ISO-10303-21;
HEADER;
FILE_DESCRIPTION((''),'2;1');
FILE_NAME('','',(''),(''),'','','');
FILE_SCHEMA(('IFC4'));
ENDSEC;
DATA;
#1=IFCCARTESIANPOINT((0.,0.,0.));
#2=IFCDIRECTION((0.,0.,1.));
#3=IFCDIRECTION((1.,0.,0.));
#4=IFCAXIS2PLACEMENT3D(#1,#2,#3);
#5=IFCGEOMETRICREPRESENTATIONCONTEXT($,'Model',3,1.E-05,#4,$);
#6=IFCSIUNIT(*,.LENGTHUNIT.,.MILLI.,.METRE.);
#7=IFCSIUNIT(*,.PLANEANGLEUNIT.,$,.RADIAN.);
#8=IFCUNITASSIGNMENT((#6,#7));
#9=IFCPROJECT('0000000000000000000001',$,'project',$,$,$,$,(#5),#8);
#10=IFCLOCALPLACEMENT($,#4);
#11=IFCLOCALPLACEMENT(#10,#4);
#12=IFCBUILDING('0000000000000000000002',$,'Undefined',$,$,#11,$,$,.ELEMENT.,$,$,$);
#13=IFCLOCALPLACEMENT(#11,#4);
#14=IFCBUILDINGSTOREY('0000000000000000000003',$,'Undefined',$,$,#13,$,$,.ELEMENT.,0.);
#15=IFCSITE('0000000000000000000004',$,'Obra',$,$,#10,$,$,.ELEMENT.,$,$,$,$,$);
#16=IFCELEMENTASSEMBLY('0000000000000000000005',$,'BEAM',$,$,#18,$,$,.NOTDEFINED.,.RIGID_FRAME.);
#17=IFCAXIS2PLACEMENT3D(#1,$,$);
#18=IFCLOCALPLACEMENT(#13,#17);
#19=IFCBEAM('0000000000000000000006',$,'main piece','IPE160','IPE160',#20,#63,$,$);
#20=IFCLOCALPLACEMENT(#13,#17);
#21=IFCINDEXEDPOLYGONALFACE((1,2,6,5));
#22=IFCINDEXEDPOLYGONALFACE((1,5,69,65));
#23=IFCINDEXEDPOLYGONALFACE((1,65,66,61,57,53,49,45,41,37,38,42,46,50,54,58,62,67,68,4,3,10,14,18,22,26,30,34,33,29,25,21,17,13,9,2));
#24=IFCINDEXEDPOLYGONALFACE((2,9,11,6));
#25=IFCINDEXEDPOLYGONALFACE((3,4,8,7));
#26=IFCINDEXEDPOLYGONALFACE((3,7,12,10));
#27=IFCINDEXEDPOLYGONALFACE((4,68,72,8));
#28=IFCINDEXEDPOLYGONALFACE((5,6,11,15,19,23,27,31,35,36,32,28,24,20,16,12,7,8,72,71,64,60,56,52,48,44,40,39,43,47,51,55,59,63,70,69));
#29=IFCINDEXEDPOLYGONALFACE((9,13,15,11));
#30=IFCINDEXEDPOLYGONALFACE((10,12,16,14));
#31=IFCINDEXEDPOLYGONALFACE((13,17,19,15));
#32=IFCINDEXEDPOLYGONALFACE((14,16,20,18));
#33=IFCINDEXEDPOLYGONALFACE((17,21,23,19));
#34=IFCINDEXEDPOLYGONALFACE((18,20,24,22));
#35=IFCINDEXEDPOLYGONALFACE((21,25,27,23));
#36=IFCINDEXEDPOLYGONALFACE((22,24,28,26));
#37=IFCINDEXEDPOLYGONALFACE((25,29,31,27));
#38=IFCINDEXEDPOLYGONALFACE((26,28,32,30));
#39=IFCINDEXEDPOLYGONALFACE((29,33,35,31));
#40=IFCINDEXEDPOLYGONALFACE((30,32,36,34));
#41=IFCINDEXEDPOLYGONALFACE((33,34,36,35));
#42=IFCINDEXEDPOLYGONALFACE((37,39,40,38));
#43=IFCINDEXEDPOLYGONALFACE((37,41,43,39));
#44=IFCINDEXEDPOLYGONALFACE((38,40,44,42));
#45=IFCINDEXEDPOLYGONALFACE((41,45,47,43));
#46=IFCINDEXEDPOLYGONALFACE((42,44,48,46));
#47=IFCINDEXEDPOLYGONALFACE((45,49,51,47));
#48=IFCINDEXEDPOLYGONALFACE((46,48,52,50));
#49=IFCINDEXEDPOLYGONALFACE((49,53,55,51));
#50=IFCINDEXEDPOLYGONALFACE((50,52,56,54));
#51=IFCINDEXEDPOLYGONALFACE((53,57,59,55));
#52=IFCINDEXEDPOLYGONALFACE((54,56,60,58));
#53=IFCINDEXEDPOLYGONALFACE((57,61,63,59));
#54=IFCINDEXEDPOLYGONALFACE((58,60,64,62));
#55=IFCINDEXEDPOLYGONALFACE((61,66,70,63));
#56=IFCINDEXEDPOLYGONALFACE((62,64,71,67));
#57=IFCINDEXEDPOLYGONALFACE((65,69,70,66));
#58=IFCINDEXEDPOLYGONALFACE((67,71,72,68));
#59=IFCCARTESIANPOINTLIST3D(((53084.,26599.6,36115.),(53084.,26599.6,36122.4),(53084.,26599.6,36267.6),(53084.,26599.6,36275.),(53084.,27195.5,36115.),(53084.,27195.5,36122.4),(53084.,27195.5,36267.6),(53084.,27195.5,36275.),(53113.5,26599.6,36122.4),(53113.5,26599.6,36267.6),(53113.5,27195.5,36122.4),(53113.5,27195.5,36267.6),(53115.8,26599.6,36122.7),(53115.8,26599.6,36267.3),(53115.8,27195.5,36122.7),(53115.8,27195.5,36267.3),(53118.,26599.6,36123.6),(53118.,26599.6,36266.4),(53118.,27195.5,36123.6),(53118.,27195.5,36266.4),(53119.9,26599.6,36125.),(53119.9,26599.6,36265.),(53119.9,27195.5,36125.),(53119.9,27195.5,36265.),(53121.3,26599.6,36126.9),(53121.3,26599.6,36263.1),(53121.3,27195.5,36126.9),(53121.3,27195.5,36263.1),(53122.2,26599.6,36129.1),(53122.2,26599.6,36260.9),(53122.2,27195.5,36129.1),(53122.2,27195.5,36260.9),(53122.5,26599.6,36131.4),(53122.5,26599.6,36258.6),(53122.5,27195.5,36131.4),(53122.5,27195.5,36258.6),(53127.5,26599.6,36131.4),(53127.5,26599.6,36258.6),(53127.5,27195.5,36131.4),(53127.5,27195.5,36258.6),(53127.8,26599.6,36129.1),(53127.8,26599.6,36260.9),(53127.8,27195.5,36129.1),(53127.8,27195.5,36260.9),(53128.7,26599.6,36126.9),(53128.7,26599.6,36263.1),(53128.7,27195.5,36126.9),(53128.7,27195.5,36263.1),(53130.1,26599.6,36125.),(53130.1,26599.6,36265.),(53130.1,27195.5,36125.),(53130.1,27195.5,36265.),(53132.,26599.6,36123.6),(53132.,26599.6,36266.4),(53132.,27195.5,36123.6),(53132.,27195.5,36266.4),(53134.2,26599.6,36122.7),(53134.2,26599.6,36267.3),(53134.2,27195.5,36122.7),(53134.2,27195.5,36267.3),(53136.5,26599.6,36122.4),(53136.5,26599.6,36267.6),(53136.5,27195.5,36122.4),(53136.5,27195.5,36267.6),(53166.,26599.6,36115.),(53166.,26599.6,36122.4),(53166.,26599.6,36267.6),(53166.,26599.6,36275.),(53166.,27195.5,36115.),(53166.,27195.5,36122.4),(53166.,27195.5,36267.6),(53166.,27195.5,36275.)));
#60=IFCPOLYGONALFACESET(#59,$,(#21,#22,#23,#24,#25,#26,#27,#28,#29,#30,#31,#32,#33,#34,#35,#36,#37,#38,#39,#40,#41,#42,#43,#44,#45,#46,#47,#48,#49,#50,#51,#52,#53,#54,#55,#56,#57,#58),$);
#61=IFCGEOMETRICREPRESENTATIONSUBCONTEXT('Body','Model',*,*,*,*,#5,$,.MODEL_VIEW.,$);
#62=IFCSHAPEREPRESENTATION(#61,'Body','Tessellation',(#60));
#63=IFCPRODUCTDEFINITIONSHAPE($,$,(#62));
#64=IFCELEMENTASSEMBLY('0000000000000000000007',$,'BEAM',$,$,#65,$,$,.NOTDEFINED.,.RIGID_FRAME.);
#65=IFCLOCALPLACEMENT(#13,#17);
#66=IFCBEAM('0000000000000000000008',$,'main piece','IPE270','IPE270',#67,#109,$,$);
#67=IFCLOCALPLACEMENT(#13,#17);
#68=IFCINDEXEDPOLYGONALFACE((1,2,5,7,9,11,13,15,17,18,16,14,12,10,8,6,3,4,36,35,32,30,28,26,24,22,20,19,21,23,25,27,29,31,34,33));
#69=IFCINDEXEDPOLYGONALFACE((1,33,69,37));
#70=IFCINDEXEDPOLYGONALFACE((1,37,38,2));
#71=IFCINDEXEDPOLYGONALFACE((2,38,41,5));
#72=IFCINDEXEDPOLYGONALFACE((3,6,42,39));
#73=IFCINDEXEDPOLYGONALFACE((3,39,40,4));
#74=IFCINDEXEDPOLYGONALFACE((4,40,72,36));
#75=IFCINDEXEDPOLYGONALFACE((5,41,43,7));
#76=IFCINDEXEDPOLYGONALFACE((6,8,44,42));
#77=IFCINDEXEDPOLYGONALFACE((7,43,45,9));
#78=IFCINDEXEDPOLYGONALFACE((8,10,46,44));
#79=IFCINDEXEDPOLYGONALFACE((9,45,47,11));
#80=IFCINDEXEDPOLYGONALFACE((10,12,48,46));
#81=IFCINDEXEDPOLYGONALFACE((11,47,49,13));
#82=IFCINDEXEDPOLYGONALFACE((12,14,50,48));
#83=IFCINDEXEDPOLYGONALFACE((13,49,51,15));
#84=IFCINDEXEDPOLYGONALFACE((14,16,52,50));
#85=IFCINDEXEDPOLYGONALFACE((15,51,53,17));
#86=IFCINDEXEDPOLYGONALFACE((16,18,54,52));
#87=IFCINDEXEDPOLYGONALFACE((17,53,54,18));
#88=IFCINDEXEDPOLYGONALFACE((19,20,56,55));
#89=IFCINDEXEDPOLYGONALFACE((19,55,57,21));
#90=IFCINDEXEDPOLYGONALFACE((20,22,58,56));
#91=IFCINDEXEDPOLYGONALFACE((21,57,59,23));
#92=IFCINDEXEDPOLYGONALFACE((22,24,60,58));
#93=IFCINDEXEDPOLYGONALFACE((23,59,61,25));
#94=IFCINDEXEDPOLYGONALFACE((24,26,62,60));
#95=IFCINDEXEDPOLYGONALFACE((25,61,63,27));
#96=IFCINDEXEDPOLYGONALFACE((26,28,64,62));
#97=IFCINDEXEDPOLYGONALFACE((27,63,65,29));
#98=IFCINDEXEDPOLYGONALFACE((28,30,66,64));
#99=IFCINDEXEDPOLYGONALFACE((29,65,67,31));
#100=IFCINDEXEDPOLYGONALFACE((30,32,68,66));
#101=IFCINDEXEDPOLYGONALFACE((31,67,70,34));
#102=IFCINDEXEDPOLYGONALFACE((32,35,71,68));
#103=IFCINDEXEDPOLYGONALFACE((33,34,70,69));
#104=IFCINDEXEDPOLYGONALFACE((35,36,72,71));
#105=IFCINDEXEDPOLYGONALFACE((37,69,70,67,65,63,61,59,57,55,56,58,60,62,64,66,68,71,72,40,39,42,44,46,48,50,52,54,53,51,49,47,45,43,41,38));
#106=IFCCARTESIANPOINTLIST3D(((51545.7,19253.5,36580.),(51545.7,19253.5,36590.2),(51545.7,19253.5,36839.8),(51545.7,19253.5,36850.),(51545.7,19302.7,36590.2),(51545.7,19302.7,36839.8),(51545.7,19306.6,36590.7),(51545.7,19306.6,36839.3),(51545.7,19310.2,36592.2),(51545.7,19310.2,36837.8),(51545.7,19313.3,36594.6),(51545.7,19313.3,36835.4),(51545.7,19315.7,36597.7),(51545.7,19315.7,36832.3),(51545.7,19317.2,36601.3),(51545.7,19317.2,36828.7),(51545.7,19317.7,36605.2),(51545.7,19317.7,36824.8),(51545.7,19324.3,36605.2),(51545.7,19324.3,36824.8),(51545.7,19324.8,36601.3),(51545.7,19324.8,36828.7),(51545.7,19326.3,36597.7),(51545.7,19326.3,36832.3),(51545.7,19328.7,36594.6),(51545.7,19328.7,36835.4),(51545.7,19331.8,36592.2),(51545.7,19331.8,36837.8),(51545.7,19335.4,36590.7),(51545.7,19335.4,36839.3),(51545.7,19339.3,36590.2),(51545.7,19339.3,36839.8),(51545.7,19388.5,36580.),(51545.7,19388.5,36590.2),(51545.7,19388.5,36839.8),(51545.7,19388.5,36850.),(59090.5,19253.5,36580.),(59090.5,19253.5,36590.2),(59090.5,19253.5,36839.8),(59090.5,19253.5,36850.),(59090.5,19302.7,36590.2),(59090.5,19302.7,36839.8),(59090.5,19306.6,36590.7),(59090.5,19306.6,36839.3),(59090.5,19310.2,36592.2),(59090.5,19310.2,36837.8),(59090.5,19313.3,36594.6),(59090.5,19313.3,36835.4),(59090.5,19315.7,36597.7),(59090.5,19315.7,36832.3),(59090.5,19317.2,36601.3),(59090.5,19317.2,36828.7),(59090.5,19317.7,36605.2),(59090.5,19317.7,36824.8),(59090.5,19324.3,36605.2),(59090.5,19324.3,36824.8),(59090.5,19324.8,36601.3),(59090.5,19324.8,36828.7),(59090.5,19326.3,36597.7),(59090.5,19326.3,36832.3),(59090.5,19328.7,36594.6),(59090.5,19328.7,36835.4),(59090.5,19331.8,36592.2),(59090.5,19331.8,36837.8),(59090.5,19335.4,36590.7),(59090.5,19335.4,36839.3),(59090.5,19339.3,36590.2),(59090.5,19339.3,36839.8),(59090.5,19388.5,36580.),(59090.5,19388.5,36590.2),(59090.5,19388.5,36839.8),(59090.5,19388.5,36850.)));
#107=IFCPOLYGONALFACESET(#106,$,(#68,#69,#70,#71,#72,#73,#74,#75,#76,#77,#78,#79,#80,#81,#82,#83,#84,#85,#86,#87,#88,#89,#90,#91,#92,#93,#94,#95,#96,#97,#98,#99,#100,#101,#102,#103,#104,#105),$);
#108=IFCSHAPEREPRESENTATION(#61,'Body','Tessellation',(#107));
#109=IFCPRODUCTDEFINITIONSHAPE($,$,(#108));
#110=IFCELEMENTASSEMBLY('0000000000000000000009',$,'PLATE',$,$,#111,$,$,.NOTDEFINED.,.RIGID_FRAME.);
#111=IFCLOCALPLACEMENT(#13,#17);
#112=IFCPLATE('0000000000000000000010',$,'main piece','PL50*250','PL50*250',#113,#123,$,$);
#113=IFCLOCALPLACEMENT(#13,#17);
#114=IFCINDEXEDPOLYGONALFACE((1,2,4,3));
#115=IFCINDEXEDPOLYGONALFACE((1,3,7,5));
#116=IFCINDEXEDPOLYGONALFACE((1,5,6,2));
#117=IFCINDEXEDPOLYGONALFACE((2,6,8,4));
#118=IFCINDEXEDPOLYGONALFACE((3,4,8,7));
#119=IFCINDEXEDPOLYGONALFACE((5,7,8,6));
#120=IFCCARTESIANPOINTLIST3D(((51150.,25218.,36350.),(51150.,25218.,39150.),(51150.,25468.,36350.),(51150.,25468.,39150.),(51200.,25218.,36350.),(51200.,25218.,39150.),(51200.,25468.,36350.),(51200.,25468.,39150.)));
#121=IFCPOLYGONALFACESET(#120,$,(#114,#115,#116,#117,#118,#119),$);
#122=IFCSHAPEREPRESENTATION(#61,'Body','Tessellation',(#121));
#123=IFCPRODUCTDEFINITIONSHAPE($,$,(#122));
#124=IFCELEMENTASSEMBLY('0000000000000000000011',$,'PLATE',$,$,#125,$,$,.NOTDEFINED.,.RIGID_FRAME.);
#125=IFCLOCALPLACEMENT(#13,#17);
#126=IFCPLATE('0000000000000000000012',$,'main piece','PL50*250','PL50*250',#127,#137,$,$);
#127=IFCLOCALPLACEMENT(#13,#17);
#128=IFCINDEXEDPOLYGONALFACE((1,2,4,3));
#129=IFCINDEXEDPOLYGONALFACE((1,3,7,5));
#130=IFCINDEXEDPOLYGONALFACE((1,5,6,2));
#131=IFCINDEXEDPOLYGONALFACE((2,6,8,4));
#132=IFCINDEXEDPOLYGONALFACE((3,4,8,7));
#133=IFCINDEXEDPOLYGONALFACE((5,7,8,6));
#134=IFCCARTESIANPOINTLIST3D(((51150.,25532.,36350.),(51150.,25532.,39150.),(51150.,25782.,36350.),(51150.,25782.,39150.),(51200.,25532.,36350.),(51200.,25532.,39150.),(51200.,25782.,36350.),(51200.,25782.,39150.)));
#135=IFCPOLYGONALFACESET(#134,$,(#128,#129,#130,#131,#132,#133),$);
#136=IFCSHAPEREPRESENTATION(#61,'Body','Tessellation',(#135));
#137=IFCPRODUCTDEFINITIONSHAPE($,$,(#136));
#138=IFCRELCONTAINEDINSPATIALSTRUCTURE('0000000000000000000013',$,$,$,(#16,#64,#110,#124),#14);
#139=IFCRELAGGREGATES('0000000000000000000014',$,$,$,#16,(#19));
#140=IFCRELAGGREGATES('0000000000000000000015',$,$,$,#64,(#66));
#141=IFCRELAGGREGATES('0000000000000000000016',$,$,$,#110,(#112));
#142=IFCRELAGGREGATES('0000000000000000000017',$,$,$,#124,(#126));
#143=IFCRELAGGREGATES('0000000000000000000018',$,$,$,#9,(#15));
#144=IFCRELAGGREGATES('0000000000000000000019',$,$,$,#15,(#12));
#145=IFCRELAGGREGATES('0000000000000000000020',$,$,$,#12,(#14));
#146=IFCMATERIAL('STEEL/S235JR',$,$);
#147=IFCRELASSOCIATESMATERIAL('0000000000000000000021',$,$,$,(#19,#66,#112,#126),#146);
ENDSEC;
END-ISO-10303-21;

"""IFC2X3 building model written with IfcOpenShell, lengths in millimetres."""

from ifc_helpers import new_model, si_unit, frame, origin_with_axes, origin_2d_with_axis, place, context, subcontext, project, spatial, polyline, i_section, outline, extrude, material, element, aggregate, save


model = new_model("IFC2X3")

# Units and contexts
model_context = context("Model", 3, precision=1e-05, world=origin_with_axes())
body_context = subcontext(model_context, "Body", "Model", "MODEL_VIEW")
ifc_project = project(units=[si_unit("LENGTHUNIT", "METRE", prefix="MILLI"), si_unit("PLANEANGLEUNIT", "RADIAN")], contexts=[model_context])

# Site, building, storey
site_placement = place(None, origin_with_axes())
site = spatial("IfcSite", under=ifc_project, at=site_placement, Name="Obra", CompositionType="ELEMENT")
building_placement = place(site_placement, origin_with_axes())
building = spatial("IfcBuilding", under=site, at=building_placement, Name="Undefined", CompositionType="ELEMENT")
storey_placement = place(building_placement, origin_with_axes())
storey = spatial("IfcBuildingStorey", under=building, at=storey_placement, Name="Undefined", CompositionType="ELEMENT", Elevation=0.0)

# Shared definitions
ifc_material_1 = material(Name="STEEL/S235JR")

# Element assemblies, beams
assembly_1_placement = place(storey_placement, origin_with_axes())
assembly_1 = element("IfcElementAssembly", 1, at=assembly_1_placement, inside=storey, Name="BEAM", AssemblyPlace="NOTDEFINED", PredefinedType="RIGID_FRAME")
beam_1_placement = place(assembly_1_placement, frame((53125.0, 26599.6, 36195.0), z_axis=(0.0, 0.0, 1.0), x_axis=(0.0, 1.0, 0.0)))
beam_1 = element("IfcBeam", 2, at=beam_1_placement, material=ifc_material_1, Name="main piece", Description="IPE160", ObjectType="IPE160", context=body_context, shape_type="SweptSolid", body=[
    extrude(i_section(OverallWidth=82.0, OverallDepth=160.0, WebThickness=5.0, FlangeThickness=7.4, FilletRadius=9.0, at=origin_2d_with_axis()), frame((595.9, 0.0, 0.0), z_axis=(-1.0, 0.0, 0.0), x_axis=(0.0, -1.0, 0.0)), (0.0, 0.0, 1.0), 595.9),
])
aggregate(assembly_1, [beam_1])
assembly_2_placement = place(storey_placement, origin_with_axes())
assembly_2 = element("IfcElementAssembly", 3, at=assembly_2_placement, inside=storey, Name="BEAM", AssemblyPlace="NOTDEFINED", PredefinedType="RIGID_FRAME")
beam_2_placement = place(assembly_2_placement, frame((51545.7, 19321.0, 36715.0), z_axis=(0.0, 0.0, 1.0), x_axis=(1.0, 0.0, 0.0)))
beam_2 = element("IfcBeam", 4, at=beam_2_placement, material=ifc_material_1, Name="main piece", Description="IPE270", ObjectType="IPE270", context=body_context, shape_type="SweptSolid", body=[
    extrude(i_section(OverallWidth=135.0, OverallDepth=270.0, WebThickness=6.6, FlangeThickness=10.2, FilletRadius=15.0, at=origin_2d_with_axis()), frame((7544.8, 0.0, 0.0), z_axis=(-1.0, 0.0, 0.0), x_axis=(0.0, -1.0, 0.0)), (0.0, 0.0, 1.0), 7544.8),
])
aggregate(assembly_2, [beam_2])

# Element assemblies, plates
assembly_3_placement = place(storey_placement, origin_with_axes())
assembly_3 = element("IfcElementAssembly", 5, at=assembly_3_placement, inside=storey, Name="PLATE", AssemblyPlace="NOTDEFINED", PredefinedType="RIGID_FRAME")
plate_1_placement = place(assembly_3_placement, frame((51175.0, 25218.0, 36350.0), z_axis=(1.0, 0.0, 0.0), x_axis=(0.0, 1.0, 0.0)))
plate_1 = element("IfcPlate", 6, at=plate_1_placement, material=ifc_material_1, Name="main piece", Description="PL50*250", ObjectType="PL50*250", context=body_context, shape_type="SweptSolid", body=[
    extrude(outline(polyline([(0.0, 0.0), (250.0, 0.0), (250.0, 2800.0), (0.0, 2800.0), (0.0, 0.0)])), frame((0.0, 0.0, -25.0), z_axis=(0.0, 0.0, 1.0), x_axis=(1.0, 0.0, 0.0)), (0.0, 0.0, 1.0), 50.0),
])
aggregate(assembly_3, [plate_1])
assembly_4_placement = place(storey_placement, origin_with_axes())
assembly_4 = element("IfcElementAssembly", 7, at=assembly_4_placement, inside=storey, Name="PLATE", AssemblyPlace="NOTDEFINED", PredefinedType="RIGID_FRAME")
plate_2_placement = place(assembly_4_placement, frame((51175.0, 25532.0, 36350.0), z_axis=(1.0, 0.0, 0.0), x_axis=(0.0, 1.0, 0.0)))
plate_2 = element("IfcPlate", 8, at=plate_2_placement, material=ifc_material_1, Name="main piece", Description="PL50*250", ObjectType="PL50*250", context=body_context, shape_type="SweptSolid", body=[
    extrude(outline(polyline([(0.0, 0.0), (250.0, 0.0), (250.0, 2800.0), (0.0, 2800.0), (0.0, 0.0)])), frame((0.0, 0.0, -25.0), z_axis=(0.0, 0.0, 1.0), x_axis=(1.0, 0.0, 0.0)), (0.0, 0.0, 1.0), 50.0),
])
aggregate(assembly_4, [plate_2])

save(model, "model.ifc")
